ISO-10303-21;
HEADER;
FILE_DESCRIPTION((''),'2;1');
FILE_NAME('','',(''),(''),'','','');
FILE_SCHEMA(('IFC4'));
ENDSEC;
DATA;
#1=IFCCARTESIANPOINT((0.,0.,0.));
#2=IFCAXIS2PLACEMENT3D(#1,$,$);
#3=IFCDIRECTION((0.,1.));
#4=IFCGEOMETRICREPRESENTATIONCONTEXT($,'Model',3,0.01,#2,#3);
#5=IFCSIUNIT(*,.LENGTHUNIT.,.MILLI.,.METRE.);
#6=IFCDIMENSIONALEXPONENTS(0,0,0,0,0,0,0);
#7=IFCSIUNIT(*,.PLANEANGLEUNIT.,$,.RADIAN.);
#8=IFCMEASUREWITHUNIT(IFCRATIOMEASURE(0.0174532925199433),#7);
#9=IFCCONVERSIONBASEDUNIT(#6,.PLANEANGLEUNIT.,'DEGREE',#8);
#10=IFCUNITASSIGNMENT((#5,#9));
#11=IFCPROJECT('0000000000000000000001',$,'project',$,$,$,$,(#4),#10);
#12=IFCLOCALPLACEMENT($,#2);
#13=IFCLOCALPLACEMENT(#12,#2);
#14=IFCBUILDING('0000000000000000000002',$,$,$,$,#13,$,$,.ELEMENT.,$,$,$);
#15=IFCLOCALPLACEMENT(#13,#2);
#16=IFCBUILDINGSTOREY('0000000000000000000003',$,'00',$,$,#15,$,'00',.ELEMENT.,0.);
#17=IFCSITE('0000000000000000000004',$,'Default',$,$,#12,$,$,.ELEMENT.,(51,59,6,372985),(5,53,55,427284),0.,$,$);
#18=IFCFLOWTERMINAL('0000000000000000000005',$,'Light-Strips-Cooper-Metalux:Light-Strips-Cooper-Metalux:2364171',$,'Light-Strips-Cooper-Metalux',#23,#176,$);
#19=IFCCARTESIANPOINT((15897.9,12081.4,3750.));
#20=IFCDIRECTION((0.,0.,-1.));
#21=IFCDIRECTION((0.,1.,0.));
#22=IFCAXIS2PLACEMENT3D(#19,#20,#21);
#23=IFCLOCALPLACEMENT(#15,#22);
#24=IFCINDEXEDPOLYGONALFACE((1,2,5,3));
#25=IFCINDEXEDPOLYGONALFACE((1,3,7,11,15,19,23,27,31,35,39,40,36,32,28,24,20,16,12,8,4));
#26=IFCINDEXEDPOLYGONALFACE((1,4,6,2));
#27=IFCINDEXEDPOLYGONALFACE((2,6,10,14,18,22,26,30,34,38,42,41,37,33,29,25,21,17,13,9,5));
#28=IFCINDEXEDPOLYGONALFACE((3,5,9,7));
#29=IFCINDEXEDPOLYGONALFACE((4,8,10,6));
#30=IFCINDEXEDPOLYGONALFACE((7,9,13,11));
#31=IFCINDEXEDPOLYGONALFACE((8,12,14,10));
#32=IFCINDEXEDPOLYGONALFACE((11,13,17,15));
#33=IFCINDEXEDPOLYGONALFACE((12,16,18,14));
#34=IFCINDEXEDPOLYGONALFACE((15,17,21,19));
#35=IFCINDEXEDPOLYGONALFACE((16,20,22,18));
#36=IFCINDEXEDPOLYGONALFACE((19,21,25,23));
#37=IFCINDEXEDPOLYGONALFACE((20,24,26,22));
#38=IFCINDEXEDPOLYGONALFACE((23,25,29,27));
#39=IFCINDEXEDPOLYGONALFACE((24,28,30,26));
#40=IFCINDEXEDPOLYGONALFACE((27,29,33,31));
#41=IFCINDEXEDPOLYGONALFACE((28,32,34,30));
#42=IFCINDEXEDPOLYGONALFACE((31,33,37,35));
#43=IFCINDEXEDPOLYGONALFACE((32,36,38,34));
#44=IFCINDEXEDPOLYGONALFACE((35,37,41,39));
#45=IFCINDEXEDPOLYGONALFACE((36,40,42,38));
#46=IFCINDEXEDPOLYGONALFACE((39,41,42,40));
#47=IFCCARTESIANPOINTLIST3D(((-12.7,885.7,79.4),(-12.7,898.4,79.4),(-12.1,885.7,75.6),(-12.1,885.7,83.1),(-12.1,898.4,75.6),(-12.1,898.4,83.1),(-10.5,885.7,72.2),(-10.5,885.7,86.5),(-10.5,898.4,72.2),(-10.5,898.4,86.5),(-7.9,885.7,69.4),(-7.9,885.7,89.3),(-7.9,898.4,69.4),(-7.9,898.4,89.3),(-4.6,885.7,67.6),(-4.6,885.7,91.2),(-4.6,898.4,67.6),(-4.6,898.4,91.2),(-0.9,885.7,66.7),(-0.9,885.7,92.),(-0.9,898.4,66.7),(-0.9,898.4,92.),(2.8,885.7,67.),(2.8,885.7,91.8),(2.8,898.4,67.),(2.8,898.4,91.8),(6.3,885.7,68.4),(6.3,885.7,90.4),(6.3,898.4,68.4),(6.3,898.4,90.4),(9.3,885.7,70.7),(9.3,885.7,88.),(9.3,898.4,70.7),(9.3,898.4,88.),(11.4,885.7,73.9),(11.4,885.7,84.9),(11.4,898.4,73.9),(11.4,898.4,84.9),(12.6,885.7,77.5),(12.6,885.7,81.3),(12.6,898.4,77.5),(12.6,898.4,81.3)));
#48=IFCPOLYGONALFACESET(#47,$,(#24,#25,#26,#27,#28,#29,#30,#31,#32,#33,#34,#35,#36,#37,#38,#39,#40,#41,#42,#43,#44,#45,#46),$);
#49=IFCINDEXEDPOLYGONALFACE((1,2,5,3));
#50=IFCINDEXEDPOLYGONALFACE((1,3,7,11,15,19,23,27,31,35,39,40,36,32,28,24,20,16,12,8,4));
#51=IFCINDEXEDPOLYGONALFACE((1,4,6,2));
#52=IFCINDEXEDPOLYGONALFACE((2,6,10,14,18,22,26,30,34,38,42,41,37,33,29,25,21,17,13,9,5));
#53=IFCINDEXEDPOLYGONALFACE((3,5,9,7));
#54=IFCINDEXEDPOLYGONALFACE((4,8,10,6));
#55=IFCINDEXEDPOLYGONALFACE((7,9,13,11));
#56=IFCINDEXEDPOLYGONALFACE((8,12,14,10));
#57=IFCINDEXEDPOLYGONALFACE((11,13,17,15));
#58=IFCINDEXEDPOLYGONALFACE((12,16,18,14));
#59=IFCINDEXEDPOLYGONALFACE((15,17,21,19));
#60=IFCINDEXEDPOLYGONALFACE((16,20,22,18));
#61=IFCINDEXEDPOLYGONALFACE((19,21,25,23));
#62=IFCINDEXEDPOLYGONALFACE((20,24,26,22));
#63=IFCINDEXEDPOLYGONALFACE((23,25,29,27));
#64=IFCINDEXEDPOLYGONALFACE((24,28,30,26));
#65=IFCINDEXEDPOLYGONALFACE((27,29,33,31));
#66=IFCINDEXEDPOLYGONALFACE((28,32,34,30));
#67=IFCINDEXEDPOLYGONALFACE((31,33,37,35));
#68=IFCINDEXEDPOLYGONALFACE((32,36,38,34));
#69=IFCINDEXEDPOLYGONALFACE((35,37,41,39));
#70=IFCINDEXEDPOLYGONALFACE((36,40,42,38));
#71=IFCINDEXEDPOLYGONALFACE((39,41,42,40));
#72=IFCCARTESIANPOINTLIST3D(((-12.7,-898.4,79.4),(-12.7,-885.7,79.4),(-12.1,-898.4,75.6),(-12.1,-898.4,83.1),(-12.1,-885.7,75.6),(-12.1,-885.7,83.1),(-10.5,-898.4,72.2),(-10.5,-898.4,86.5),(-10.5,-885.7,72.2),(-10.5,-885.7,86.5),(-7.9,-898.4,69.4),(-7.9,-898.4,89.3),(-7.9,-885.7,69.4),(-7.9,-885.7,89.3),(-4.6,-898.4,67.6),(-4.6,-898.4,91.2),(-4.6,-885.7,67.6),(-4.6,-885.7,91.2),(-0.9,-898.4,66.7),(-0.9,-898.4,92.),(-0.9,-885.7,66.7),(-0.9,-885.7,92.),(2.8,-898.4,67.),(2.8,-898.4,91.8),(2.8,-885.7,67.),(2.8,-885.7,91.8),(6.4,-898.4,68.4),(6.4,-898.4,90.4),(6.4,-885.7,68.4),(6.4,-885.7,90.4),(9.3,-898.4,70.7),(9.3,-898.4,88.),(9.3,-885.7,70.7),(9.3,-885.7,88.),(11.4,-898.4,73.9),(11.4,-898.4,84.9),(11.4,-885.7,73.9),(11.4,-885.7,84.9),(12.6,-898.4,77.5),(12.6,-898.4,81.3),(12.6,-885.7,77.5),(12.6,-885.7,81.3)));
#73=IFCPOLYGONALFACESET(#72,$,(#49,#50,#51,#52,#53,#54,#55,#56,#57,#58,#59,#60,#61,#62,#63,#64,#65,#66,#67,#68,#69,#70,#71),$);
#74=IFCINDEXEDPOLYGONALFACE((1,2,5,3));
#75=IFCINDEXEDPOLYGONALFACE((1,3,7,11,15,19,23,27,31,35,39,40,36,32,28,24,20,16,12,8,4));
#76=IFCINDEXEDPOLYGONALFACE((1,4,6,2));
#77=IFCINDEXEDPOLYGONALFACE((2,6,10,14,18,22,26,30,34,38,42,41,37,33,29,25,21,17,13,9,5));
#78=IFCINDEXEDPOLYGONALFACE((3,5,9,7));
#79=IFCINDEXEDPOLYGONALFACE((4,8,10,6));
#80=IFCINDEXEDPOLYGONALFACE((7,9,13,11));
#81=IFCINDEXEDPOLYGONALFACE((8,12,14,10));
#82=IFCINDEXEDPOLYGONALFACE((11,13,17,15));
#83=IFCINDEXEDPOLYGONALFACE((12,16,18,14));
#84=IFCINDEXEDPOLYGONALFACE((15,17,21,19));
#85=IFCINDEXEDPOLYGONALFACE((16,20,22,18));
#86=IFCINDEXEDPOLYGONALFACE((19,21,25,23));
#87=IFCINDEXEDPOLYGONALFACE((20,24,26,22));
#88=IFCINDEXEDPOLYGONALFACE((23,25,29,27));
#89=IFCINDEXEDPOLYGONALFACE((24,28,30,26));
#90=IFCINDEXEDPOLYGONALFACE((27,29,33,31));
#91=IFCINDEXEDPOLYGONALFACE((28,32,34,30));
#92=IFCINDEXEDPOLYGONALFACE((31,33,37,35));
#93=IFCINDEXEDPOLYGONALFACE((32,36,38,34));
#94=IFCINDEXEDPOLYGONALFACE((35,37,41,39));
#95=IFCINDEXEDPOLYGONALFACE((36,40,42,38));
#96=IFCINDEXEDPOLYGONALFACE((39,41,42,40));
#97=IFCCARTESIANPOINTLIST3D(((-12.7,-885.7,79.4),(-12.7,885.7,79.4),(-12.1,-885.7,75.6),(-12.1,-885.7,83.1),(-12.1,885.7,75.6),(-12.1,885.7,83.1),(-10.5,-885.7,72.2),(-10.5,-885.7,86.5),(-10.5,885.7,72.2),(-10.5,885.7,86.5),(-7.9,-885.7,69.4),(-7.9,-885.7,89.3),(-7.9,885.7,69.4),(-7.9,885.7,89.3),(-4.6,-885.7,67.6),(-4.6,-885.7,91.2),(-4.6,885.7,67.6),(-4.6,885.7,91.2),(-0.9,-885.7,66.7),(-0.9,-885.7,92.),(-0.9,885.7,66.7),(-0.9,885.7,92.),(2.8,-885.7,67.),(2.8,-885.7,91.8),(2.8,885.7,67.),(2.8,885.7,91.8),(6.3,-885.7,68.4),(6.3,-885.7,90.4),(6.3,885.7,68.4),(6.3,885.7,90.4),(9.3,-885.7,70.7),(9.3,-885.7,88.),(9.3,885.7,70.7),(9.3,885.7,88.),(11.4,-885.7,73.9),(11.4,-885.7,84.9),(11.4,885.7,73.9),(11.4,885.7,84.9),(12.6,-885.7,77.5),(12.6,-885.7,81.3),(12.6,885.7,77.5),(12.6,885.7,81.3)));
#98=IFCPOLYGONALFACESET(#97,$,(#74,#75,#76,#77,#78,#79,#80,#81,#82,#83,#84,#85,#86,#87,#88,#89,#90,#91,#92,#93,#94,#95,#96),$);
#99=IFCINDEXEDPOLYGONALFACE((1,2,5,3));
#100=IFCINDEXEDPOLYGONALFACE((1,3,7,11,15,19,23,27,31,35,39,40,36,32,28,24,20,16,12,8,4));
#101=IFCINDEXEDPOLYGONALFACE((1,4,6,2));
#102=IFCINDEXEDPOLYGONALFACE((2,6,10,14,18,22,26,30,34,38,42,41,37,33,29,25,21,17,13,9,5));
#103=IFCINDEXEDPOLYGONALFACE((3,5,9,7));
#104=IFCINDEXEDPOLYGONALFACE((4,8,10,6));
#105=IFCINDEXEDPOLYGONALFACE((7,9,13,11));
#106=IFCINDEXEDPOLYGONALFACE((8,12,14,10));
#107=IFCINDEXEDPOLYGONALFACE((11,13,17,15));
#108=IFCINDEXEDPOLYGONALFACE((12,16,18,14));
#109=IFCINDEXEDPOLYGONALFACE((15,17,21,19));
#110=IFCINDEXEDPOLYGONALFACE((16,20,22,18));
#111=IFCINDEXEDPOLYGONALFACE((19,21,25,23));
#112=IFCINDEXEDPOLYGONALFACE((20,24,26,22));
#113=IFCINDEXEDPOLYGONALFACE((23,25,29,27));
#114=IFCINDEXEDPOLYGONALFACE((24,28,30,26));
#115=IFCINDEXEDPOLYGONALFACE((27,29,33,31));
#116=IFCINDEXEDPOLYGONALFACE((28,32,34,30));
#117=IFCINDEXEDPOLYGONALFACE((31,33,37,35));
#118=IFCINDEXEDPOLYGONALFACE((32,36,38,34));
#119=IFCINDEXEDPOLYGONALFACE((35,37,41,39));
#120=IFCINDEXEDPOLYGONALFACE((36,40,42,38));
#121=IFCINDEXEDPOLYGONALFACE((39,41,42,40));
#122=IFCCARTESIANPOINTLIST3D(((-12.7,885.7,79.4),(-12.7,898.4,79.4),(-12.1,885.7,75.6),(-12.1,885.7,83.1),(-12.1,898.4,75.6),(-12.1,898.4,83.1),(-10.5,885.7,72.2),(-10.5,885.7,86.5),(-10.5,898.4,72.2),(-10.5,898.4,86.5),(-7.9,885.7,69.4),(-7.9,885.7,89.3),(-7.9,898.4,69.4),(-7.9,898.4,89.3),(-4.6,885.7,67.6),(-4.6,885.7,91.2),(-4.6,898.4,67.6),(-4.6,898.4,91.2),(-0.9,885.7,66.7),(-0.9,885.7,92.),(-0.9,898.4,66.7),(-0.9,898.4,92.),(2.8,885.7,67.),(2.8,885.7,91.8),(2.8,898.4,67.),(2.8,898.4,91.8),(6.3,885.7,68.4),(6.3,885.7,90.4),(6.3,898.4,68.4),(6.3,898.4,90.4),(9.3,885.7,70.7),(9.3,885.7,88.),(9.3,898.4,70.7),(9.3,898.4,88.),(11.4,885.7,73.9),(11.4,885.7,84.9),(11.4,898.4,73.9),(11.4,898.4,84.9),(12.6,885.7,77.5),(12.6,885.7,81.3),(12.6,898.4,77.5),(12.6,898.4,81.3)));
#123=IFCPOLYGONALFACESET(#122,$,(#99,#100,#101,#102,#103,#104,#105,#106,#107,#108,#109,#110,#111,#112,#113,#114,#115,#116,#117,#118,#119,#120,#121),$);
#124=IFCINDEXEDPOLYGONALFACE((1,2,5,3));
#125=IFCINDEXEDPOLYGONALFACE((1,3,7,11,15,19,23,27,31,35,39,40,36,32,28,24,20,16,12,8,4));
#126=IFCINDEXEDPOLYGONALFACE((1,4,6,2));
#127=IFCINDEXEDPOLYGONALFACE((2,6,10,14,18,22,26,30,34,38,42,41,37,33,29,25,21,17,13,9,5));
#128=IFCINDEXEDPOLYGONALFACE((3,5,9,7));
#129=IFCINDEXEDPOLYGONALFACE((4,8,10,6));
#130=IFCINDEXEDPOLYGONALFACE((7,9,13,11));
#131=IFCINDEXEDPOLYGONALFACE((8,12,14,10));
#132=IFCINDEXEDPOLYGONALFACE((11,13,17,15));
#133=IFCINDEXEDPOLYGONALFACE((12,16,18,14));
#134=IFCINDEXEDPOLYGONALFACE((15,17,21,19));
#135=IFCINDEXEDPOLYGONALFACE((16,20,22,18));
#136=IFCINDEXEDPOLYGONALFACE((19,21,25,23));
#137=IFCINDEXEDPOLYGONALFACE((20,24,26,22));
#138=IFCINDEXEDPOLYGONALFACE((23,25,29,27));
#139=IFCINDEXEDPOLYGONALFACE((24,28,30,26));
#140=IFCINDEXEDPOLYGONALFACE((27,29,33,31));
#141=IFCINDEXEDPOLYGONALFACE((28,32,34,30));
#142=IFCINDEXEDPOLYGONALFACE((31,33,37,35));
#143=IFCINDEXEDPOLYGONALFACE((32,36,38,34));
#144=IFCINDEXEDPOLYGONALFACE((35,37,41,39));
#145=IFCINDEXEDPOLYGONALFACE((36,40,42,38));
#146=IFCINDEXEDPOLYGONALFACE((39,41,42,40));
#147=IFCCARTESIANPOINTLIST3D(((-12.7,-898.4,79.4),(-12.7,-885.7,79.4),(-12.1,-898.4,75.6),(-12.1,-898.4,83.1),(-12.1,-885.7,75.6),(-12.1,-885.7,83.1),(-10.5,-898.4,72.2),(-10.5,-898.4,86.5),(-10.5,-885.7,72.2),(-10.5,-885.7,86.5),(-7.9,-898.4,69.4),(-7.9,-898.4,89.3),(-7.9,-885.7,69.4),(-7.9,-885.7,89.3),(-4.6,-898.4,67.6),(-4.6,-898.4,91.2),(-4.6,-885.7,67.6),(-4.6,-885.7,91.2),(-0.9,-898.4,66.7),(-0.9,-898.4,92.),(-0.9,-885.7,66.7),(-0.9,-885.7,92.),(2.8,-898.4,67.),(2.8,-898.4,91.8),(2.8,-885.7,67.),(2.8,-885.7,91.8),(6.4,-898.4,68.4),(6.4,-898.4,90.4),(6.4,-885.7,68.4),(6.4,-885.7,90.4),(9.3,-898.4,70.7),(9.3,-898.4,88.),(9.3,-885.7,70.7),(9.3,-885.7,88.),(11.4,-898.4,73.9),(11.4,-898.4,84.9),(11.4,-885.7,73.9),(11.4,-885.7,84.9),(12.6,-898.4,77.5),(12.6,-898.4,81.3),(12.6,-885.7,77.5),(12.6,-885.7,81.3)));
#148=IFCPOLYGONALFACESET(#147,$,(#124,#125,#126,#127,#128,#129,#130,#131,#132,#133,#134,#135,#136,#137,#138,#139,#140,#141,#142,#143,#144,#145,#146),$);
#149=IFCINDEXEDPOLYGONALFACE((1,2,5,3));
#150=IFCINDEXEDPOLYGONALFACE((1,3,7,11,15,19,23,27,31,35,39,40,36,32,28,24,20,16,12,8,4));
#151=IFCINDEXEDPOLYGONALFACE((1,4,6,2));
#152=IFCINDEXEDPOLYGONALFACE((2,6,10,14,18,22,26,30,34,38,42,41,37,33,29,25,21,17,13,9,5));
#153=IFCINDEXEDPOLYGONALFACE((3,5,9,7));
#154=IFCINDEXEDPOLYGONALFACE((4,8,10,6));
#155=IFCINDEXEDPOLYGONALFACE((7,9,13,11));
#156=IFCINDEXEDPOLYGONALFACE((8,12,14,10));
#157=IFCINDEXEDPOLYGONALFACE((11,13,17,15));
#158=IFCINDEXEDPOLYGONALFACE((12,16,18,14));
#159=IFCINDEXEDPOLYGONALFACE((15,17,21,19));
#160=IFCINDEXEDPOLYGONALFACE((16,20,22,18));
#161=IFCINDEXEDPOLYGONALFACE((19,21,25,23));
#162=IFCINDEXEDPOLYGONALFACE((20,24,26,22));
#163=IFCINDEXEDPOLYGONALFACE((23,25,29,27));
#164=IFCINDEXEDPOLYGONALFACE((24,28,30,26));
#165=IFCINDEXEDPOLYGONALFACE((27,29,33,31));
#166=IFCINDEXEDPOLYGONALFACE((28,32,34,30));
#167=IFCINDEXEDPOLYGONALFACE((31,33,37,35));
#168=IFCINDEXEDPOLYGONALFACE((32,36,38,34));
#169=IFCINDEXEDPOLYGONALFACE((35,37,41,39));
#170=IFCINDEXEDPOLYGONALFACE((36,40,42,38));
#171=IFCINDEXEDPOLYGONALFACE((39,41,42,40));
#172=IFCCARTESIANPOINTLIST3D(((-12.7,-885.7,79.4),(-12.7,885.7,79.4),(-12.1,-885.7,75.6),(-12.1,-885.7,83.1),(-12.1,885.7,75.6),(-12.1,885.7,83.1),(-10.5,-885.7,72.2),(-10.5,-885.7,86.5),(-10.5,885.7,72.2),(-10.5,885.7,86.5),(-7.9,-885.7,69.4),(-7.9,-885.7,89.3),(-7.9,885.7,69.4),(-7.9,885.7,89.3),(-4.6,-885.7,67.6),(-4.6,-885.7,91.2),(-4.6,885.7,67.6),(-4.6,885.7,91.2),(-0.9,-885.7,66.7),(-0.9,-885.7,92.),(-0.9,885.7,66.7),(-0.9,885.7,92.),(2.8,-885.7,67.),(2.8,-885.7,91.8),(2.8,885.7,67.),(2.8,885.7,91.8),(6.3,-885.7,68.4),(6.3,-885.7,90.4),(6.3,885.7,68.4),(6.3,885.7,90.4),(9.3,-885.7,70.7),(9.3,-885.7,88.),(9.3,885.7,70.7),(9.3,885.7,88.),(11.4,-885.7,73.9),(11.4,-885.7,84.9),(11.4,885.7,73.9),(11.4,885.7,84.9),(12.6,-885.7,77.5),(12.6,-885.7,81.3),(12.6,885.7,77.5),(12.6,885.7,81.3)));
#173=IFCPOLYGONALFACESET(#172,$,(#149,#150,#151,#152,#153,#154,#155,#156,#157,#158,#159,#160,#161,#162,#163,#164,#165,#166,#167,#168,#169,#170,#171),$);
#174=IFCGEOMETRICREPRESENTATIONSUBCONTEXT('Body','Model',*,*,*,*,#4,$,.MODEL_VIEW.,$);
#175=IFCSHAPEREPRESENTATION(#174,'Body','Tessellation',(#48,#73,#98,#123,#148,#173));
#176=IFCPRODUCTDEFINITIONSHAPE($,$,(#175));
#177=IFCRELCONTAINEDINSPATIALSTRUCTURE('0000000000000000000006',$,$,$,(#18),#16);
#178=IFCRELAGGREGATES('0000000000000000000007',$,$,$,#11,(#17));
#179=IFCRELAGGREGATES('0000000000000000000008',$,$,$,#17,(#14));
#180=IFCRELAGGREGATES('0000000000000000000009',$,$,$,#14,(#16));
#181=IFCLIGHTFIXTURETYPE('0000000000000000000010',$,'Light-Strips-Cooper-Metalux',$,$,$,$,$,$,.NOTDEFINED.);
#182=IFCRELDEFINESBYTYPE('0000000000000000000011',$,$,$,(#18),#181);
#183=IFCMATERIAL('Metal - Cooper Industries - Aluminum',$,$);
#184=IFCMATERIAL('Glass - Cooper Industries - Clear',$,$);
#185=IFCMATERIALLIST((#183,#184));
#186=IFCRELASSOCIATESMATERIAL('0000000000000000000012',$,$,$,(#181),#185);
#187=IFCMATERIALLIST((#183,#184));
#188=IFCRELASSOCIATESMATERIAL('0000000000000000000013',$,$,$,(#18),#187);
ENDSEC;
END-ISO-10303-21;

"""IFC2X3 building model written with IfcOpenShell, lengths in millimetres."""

from ifc_helpers import new_model, entity, si_unit, converted_unit, direction, frame, frame_2d, origin, place, context, subcontext, project, spatial, circle, extrude, source, transform, mapped, material, material_list, type_object, type_shapes, element, save


model = new_model("IFC2X3")

# Units and contexts
model_context = context("Model", 3, precision=0.01, world=origin(), true_north=direction((0.0, 1.0)))
body_context = subcontext(model_context, "Body", "Model", "MODEL_VIEW")
ifc_project = project(units=[si_unit("LENGTHUNIT", "METRE", prefix="MILLI"), converted_unit("PLANEANGLEUNIT", "DEGREE", entity("IfcRatioMeasure", 0.0174532925199433), si_unit("PLANEANGLEUNIT", "RADIAN"), dimensions=[0, 0, 0, 0, 0, 0, 0])], contexts=[model_context])

# Site, building, storey
site_placement = place(None, origin())
site = spatial("IfcSite", under=ifc_project, at=site_placement, Name="Default", CompositionType="ELEMENT", RefLatitude=(51, 59, 6, 372985), RefLongitude=(5, 53, 55, 427284), RefElevation=0.0)
building_placement = place(site_placement, origin())
building = spatial("IfcBuilding", under=site, at=building_placement, CompositionType="ELEMENT")
storey_placement = place(building_placement, origin())
storey = spatial("IfcBuildingStorey", under=building, at=storey_placement, Name="00", LongName="00", CompositionType="ELEMENT", Elevation=0.0)

# Flow terminal
ifc_material_1 = material(Name="Metal - Cooper Industries - Aluminum")
ifc_material_2 = material(Name="Glass - Cooper Industries - Clear")
ifc_material_list_1 = material_list([ifc_material_1, ifc_material_2])
light_fixture_type = type_object("IfcLightFixtureType", Name="Light-Strips-Cooper-Metalux", PredefinedType="NOTDEFINED", material=ifc_material_list_1)
shared_shape_1 = source(origin(), body_context, "Body", "SweptSolid", [
    extrude(circle(Radius=12.7, at=frame_2d((0.0, 0.0), x_axis=(1.0, 0.0))), frame((0.0, 885.7, 79.4), z_axis=(0.0, 1.0, 0.0), x_axis=(-1.0, 0.0, 0.0)), (0.0, 0.0, 1.0), 12.7),
    extrude(circle(Radius=12.7, at=frame_2d((0.0, 0.0), x_axis=(1.0, 0.0))), frame((0.0, -898.4, 79.4), z_axis=(0.0, 1.0, 0.0), x_axis=(-1.0, 0.0, 0.0)), (0.0, 0.0, 1.0), 12.7),
    extrude(circle(Radius=12.7, at=frame_2d((0.0, 0.0), x_axis=(1.0, 0.0))), frame((0.0, -885.7, 79.4), z_axis=(0.0, 1.0, 0.0), x_axis=(-1.0, 0.0, 0.0)), (0.0, 0.0, 1.0), 1771.4),
    extrude(circle(Radius=12.7, at=frame_2d((0.0, 0.0), x_axis=(1.0, 0.0))), frame((0.0, 885.7, 79.4), z_axis=(0.0, 1.0, 0.0), x_axis=(-1.0, 0.0, 0.0)), (0.0, 0.0, 1.0), 12.7),
    extrude(circle(Radius=12.7, at=frame_2d((0.0, 0.0), x_axis=(1.0, 0.0))), frame((0.0, -898.4, 79.4), z_axis=(0.0, 1.0, 0.0), x_axis=(-1.0, 0.0, 0.0)), (0.0, 0.0, 1.0), 12.7),
    extrude(circle(Radius=12.7, at=frame_2d((0.0, 0.0), x_axis=(1.0, 0.0))), frame((0.0, -885.7, 79.4), z_axis=(0.0, 1.0, 0.0), x_axis=(-1.0, 0.0, 0.0)), (0.0, 0.0, 1.0), 1771.4),
])
type_shapes(light_fixture_type, [shared_shape_1])
ifc_material_list_2 = material_list([ifc_material_1, ifc_material_2])
flow_terminal_1_placement = place(storey_placement, frame((15897.9, 12081.4, 3750.0), z_axis=(0.0, 0.0, -1.0), x_axis=(0.0, 1.0, 0.0)))
element("IfcFlowTerminal", 1, at=flow_terminal_1_placement, inside=storey, type_object=light_fixture_type, material=ifc_material_list_2, Name="Light-Strips-Cooper-Metalux:Light-Strips-Cooper-Metalux:2364171", ObjectType="Light-Strips-Cooper-Metalux", context=body_context, shape_type="MappedRepresentation", body=[
    mapped(shared_shape_1, transform((0.0, 0.0, 0.0), scale=1.0)),
])

save(model, "model.ifc")
